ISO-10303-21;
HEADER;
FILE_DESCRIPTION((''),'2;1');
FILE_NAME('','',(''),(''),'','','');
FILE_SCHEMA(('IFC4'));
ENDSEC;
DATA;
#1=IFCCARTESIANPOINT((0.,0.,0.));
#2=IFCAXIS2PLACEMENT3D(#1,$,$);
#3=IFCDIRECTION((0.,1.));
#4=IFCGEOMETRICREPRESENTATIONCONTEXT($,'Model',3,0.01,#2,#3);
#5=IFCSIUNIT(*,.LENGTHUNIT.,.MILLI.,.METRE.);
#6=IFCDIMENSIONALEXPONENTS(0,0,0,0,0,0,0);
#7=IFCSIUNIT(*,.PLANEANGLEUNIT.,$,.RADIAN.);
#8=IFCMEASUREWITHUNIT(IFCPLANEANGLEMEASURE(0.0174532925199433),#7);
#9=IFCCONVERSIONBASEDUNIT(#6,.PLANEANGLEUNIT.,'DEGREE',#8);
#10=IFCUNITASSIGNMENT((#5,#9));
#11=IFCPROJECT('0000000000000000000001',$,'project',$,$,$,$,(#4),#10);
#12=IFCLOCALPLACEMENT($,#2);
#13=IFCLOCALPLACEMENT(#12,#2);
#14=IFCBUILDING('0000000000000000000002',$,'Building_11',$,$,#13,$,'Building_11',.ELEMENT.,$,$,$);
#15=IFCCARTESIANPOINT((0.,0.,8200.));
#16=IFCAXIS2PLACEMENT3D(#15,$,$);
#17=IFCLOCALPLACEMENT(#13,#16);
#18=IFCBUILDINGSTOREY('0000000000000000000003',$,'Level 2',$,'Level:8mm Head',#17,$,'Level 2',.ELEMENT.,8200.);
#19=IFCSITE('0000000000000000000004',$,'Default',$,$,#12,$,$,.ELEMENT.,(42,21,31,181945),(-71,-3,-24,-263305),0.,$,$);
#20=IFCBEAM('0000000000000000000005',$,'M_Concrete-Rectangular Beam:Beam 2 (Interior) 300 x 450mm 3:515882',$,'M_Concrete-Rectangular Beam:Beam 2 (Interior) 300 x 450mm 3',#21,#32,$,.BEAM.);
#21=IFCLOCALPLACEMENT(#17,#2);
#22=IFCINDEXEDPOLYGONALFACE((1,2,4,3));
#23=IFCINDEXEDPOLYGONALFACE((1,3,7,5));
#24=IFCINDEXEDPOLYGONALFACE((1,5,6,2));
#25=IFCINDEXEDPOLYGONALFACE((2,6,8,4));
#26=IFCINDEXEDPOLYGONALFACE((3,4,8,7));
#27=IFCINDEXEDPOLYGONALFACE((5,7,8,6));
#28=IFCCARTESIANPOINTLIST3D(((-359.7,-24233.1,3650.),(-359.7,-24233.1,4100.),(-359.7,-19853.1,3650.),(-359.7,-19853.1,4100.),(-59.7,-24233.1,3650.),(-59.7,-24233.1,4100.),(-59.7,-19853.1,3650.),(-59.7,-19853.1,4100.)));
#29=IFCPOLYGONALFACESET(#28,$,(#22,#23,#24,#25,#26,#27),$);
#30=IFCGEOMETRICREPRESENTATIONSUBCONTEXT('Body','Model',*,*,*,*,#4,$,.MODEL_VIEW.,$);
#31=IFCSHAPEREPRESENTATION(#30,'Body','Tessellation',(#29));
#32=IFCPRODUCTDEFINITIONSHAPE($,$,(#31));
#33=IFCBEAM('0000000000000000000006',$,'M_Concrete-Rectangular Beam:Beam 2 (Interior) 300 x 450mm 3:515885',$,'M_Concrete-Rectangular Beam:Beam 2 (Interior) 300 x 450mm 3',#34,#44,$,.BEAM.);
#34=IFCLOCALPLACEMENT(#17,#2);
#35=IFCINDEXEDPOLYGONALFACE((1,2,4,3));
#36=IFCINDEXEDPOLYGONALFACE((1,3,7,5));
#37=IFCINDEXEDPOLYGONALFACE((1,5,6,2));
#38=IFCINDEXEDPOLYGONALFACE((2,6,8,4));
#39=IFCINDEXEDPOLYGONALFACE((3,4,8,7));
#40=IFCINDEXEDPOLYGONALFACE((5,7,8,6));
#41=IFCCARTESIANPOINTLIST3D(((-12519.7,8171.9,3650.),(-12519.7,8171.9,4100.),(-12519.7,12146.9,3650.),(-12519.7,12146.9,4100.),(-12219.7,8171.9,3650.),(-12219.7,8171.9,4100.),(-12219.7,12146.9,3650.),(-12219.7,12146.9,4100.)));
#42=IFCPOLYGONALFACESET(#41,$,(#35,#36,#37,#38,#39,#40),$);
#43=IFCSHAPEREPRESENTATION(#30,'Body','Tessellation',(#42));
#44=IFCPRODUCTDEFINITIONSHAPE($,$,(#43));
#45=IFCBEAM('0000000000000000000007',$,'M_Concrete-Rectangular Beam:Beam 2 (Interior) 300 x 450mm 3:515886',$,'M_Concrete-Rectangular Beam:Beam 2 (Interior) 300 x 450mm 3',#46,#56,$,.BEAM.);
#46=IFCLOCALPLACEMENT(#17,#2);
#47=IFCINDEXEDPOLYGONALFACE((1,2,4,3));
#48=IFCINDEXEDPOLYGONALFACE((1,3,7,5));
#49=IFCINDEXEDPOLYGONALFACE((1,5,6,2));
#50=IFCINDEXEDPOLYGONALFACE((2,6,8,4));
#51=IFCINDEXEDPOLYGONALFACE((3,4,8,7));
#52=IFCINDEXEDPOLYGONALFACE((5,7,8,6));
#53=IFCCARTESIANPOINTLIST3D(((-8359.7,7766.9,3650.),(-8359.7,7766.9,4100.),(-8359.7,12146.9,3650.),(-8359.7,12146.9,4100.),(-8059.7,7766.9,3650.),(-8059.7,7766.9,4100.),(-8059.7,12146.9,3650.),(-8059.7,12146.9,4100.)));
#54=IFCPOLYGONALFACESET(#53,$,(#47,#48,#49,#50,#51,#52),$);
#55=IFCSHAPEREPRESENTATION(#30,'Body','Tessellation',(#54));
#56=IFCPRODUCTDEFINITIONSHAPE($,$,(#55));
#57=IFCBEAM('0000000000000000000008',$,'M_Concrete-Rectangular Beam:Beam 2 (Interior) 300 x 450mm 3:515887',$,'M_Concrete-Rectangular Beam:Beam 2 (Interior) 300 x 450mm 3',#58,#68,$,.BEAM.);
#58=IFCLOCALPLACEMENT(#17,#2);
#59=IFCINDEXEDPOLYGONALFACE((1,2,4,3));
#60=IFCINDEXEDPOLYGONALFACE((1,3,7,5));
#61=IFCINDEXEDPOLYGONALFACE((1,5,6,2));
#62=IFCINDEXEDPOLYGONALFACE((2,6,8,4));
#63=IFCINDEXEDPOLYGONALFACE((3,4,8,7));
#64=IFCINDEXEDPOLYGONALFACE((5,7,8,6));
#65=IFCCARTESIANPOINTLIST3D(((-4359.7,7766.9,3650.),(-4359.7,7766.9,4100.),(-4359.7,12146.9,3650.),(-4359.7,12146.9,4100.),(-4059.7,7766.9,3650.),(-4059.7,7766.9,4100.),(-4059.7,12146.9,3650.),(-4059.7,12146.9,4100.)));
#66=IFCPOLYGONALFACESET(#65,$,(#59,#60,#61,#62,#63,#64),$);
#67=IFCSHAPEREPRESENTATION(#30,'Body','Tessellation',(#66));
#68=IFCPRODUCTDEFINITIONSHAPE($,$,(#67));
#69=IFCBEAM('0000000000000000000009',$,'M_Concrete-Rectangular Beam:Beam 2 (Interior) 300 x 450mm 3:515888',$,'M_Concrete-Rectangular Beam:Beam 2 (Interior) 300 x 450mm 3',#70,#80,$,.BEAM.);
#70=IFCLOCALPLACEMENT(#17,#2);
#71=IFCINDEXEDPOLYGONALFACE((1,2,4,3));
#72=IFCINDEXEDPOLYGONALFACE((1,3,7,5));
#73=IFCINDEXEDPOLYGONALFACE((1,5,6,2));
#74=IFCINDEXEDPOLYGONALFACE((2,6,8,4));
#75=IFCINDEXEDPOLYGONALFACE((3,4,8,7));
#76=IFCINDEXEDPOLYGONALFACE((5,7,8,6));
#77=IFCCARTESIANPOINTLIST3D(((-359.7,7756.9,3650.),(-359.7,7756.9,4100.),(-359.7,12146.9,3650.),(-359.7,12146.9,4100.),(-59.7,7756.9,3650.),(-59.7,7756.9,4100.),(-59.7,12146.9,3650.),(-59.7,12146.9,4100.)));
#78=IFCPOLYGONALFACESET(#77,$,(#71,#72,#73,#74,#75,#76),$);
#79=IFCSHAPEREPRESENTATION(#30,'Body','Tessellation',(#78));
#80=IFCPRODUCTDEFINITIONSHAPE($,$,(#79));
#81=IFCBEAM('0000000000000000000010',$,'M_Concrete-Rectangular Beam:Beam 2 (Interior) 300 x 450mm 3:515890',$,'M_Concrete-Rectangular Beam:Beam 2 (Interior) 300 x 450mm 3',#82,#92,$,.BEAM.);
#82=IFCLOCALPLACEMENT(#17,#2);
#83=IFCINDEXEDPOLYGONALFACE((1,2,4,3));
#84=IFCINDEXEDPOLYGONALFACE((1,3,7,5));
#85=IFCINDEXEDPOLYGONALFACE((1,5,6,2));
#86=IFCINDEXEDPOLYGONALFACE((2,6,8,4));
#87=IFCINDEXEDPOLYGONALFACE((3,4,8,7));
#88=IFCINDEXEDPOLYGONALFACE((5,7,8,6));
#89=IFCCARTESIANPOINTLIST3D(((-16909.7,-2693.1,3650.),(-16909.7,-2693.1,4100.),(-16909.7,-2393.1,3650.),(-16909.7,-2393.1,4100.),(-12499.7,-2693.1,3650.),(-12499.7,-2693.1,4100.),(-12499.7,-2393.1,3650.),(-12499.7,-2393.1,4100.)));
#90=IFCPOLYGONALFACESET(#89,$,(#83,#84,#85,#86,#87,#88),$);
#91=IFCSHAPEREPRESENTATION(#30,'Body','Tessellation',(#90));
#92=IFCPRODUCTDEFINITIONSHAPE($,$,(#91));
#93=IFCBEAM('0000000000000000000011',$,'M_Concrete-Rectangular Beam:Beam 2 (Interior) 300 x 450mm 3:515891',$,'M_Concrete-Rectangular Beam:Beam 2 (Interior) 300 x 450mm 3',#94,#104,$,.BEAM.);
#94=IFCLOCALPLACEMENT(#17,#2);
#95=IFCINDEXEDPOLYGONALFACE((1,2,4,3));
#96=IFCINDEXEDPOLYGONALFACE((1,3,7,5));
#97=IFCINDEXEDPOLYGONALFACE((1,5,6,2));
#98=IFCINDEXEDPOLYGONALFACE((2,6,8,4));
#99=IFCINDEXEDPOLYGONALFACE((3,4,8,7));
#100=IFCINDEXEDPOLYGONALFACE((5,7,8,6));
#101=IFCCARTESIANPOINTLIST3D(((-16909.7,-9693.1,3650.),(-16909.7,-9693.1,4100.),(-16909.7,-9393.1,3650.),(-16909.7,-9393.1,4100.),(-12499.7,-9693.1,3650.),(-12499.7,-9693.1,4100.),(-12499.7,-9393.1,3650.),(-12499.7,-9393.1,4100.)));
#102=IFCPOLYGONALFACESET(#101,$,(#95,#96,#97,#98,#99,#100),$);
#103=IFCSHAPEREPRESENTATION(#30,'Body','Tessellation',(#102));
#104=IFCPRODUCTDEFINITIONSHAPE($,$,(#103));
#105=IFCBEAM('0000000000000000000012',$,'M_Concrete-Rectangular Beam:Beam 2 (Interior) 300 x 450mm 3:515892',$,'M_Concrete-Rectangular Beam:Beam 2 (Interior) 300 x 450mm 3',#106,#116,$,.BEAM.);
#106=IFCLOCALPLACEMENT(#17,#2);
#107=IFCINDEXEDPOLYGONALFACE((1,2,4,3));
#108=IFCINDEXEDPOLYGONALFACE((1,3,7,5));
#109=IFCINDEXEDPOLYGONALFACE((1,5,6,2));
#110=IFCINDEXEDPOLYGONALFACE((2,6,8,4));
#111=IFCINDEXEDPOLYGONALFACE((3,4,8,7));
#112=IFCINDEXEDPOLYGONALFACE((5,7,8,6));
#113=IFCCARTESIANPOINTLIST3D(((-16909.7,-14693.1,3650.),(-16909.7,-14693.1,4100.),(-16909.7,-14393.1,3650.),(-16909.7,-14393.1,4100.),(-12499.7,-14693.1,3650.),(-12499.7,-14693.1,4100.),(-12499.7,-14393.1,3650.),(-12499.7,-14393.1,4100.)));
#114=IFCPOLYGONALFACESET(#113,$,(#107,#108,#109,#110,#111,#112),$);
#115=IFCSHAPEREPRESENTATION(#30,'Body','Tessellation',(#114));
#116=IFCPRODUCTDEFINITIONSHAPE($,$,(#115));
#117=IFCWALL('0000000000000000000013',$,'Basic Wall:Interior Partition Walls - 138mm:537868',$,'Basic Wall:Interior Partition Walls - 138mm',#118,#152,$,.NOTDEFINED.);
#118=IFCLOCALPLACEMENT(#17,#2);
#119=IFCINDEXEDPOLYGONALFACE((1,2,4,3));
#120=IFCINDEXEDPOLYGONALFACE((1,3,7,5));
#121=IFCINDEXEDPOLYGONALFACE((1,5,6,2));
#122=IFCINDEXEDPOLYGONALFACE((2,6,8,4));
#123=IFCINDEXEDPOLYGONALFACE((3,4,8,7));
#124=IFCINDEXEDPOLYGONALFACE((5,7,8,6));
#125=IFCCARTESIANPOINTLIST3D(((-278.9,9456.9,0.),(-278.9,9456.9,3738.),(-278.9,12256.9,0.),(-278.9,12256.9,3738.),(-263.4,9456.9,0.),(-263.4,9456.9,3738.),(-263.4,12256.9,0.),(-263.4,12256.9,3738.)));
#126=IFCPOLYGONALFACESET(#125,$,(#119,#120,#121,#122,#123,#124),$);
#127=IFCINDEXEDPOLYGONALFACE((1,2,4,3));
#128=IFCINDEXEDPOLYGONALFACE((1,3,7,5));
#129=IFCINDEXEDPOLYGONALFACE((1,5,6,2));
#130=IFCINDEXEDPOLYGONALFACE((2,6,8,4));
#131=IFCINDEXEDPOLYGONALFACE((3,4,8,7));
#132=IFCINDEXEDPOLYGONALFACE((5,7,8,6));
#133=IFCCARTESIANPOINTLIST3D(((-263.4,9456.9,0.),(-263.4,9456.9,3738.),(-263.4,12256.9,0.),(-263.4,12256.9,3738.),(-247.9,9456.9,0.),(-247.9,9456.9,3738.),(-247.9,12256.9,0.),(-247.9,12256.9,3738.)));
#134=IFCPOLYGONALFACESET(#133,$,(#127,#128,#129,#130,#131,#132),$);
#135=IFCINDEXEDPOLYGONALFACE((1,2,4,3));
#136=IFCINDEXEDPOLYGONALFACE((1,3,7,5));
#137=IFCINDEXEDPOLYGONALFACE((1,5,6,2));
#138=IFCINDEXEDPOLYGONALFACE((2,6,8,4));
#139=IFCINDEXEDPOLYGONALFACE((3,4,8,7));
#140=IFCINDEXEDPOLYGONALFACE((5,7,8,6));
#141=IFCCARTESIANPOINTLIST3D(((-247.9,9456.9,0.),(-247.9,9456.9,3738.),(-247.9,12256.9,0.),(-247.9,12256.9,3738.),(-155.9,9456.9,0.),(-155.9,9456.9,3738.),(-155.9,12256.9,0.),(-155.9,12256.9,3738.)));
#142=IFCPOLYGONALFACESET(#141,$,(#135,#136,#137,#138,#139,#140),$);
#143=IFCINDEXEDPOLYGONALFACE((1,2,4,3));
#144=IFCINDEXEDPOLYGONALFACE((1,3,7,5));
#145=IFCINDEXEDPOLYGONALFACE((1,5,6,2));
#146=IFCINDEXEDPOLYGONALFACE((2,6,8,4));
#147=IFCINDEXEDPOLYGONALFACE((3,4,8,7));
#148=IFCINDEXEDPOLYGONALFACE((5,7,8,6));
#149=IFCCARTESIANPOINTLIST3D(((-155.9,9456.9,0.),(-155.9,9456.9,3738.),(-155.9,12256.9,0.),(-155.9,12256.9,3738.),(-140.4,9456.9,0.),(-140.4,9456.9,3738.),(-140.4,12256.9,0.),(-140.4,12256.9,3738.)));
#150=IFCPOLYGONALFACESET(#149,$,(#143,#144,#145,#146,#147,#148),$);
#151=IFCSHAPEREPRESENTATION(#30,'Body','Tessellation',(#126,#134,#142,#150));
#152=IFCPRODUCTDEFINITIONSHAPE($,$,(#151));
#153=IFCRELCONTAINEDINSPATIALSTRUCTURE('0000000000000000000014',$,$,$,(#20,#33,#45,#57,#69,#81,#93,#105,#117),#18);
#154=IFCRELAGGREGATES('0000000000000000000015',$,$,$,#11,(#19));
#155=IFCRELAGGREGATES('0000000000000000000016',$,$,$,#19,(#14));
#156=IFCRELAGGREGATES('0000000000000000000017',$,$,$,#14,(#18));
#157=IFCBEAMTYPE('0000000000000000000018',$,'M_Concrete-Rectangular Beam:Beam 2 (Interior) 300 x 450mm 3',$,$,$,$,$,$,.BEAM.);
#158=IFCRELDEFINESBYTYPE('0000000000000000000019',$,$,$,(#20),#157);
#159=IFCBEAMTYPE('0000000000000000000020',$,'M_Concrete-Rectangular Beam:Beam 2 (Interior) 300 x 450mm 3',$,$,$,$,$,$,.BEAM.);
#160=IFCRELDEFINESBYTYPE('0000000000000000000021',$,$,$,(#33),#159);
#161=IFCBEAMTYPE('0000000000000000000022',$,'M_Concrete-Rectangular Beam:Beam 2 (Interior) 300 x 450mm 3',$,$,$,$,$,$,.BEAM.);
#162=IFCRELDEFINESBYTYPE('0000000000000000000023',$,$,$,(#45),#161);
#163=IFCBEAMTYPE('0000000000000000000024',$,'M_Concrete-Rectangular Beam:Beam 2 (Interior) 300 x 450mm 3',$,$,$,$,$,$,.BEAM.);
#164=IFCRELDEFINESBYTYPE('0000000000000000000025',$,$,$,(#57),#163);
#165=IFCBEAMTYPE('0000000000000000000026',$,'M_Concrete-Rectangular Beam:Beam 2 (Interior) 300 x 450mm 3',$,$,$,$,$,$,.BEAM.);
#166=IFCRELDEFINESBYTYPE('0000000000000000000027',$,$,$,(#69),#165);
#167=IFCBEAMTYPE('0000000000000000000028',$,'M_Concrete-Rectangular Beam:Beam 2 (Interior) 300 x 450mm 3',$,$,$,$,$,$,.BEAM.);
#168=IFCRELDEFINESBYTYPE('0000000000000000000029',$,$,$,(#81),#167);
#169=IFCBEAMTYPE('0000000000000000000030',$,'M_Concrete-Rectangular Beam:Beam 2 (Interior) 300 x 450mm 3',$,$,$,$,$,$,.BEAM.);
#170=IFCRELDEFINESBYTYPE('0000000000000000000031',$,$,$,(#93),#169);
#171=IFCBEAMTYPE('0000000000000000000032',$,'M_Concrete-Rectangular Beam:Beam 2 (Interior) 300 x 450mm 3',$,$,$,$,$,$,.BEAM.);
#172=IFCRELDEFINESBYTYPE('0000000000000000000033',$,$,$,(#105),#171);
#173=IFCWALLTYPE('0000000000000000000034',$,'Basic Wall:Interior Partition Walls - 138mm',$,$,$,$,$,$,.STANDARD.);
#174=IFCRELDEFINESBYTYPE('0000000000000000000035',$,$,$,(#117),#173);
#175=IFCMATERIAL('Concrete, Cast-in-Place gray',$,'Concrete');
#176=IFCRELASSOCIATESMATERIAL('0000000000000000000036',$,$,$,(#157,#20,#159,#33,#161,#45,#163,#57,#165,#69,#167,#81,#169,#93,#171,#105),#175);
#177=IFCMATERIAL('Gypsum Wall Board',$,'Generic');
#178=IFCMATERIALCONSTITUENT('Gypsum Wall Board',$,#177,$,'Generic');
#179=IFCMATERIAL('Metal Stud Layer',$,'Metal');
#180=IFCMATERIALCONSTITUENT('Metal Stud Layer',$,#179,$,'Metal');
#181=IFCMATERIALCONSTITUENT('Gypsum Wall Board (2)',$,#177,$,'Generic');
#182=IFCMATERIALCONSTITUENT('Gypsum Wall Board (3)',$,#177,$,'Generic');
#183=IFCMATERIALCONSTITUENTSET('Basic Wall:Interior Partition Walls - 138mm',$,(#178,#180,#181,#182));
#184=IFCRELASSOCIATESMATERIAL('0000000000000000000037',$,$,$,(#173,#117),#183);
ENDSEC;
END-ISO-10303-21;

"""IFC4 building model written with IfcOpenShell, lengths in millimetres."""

from ifc_helpers import new_model, entity, si_unit, converted_unit, direction, frame, origin, place, context, subcontext, project, spatial, indexed_curve, outline, extrude, source, transform, mapped, material, constituent, constituent_set, type_object, type_shapes, element, save


model = new_model("IFC4")

# Units and contexts
model_context = context("Model", 3, precision=0.01, world=origin(), true_north=direction((0.0, 1.0)))
body_context = subcontext(model_context, "Body", "Model", "MODEL_VIEW")
ifc_project = project(units=[si_unit("LENGTHUNIT", "METRE", prefix="MILLI"), converted_unit("PLANEANGLEUNIT", "DEGREE", entity("IfcPlaneAngleMeasure", 0.0174532925199433), si_unit("PLANEANGLEUNIT", "RADIAN"), dimensions=[0, 0, 0, 0, 0, 0, 0])], contexts=[model_context])

# Site, building, storey
site_placement = place(None, origin())
site = spatial("IfcSite", under=ifc_project, at=site_placement, Name="Default", CompositionType="ELEMENT", RefLatitude=(42, 21, 31, 181945), RefLongitude=(-71, -3, -24, -263305), RefElevation=0.0)
building_placement = place(site_placement, origin())
building = spatial("IfcBuilding", under=site, at=building_placement, Name="Building_11", LongName="Building_11", CompositionType="ELEMENT")
storey_placement = place(building_placement, frame((0.0, 0.0, 8200.0)))
storey = spatial("IfcBuildingStorey", under=building, at=storey_placement, Name="Level 2", ObjectType="Level:8mm Head", LongName="Level 2", CompositionType="ELEMENT", Elevation=8200.0)

# Beams
ifc_material_1 = material(Name="Concrete, Cast-in-Place gray", Category="Concrete")
beam_type_1 = type_object("IfcBeamType", Name="M_Concrete-Rectangular Beam:Beam 2 (Interior) 300 x 450mm 3", PredefinedType="BEAM", material=ifc_material_1)
shared_shape_1 = source(origin(), body_context, "Body", "SweptSolid", [
    extrude(outline(indexed_curve([(-150.0, -225.0), (150.0, -225.0), (150.0, 225.0), (-150.0, 225.0), (-150.0, -225.0)], self_intersect=False)), frame((-209.7, -19853.1, 12075.0), z_axis=(0.0, -1.0, 0.0), x_axis=(-1.0, 0.0, 0.0)), (0.0, 0.0, 1.0), 4380.0),
])
type_shapes(beam_type_1, [shared_shape_1])
beam_1_placement = place(storey_placement, frame((0.0, 0.0, -8200.0)))
element("IfcBeam", 1, at=beam_1_placement, inside=storey, type_object=beam_type_1, material=ifc_material_1, Name="M_Concrete-Rectangular Beam:Beam 2 (Interior) 300 x 450mm 3:515882", ObjectType="M_Concrete-Rectangular Beam:Beam 2 (Interior) 300 x 450mm 3", PredefinedType="BEAM", context=body_context, shape_type="MappedRepresentation", body=[
    mapped(shared_shape_1, transform((0.0, 0.0, 0.0), scale=1.0)),
])
beam_type_2 = type_object("IfcBeamType", Name="M_Concrete-Rectangular Beam:Beam 2 (Interior) 300 x 450mm 3", PredefinedType="BEAM", material=ifc_material_1)
shared_shape_2 = source(origin(), body_context, "Body", "SweptSolid", [
    extrude(outline(indexed_curve([(-150.0, -225.0), (150.0, -225.0), (150.0, 225.0), (-150.0, 225.0), (-150.0, -225.0)], self_intersect=False)), frame((-12369.7, 12146.9, 12075.0), z_axis=(0.0, -1.0, 0.0), x_axis=(-1.0, 0.0, 0.0)), (0.0, 0.0, 1.0), 3975.0),
])
type_shapes(beam_type_2, [shared_shape_2])
beam_2_placement = place(storey_placement, frame((0.0, 0.0, -8200.0)))
element("IfcBeam", 2, at=beam_2_placement, inside=storey, type_object=beam_type_2, material=ifc_material_1, Name="M_Concrete-Rectangular Beam:Beam 2 (Interior) 300 x 450mm 3:515885", ObjectType="M_Concrete-Rectangular Beam:Beam 2 (Interior) 300 x 450mm 3", PredefinedType="BEAM", context=body_context, shape_type="MappedRepresentation", body=[
    mapped(shared_shape_2, transform((0.0, 0.0, 0.0), scale=1.0)),
])
beam_type_3 = type_object("IfcBeamType", Name="M_Concrete-Rectangular Beam:Beam 2 (Interior) 300 x 450mm 3", PredefinedType="BEAM", material=ifc_material_1)
shared_shape_3 = source(origin(), body_context, "Body", "SweptSolid", [
    extrude(outline(indexed_curve([(-150.0, -225.0), (150.0, -225.0), (150.0, 225.0), (-150.0, 225.0), (-150.0, -225.0)], self_intersect=False)), frame((-8209.7, 12146.9, 12075.0), z_axis=(0.0, -1.0, 0.0), x_axis=(-1.0, 0.0, 0.0)), (0.0, 0.0, 1.0), 4380.0),
])
type_shapes(beam_type_3, [shared_shape_3])
beam_3_placement = place(storey_placement, frame((0.0, 0.0, -8200.0)))
element("IfcBeam", 3, at=beam_3_placement, inside=storey, type_object=beam_type_3, material=ifc_material_1, Name="M_Concrete-Rectangular Beam:Beam 2 (Interior) 300 x 450mm 3:515886", ObjectType="M_Concrete-Rectangular Beam:Beam 2 (Interior) 300 x 450mm 3", PredefinedType="BEAM", context=body_context, shape_type="MappedRepresentation", body=[
    mapped(shared_shape_3, transform((0.0, 0.0, 0.0), scale=1.0)),
])
beam_type_4 = type_object("IfcBeamType", Name="M_Concrete-Rectangular Beam:Beam 2 (Interior) 300 x 450mm 3", PredefinedType="BEAM", material=ifc_material_1)
shared_shape_4 = source(origin(), body_context, "Body", "SweptSolid", [
    extrude(outline(indexed_curve([(-150.0, -225.0), (150.0, -225.0), (150.0, 225.0), (-150.0, 225.0), (-150.0, -225.0)], self_intersect=False)), frame((-4209.7, 12146.9, 12075.0), z_axis=(0.0, -1.0, 0.0), x_axis=(-1.0, 0.0, 0.0)), (0.0, 0.0, 1.0), 4380.0),
])
type_shapes(beam_type_4, [shared_shape_4])
beam_4_placement = place(storey_placement, frame((0.0, 0.0, -8200.0)))
element("IfcBeam", 4, at=beam_4_placement, inside=storey, type_object=beam_type_4, material=ifc_material_1, Name="M_Concrete-Rectangular Beam:Beam 2 (Interior) 300 x 450mm 3:515887", ObjectType="M_Concrete-Rectangular Beam:Beam 2 (Interior) 300 x 450mm 3", PredefinedType="BEAM", context=body_context, shape_type="MappedRepresentation", body=[
    mapped(shared_shape_4, transform((0.0, 0.0, 0.0), scale=1.0)),
])
beam_type_5 = type_object("IfcBeamType", Name="M_Concrete-Rectangular Beam:Beam 2 (Interior) 300 x 450mm 3", PredefinedType="BEAM", material=ifc_material_1)
shared_shape_5 = source(origin(), body_context, "Body", "SweptSolid", [
    extrude(outline(indexed_curve([(-150.0, -225.0), (150.0, -225.0), (150.0, 225.0), (-150.0, 225.0), (-150.0, -225.0)], self_intersect=False)), frame((-209.7, 12146.9, 12075.0), z_axis=(0.0, -1.0, 0.0), x_axis=(-1.0, 0.0, 0.0)), (0.0, 0.0, 1.0), 4390.0),
])
type_shapes(beam_type_5, [shared_shape_5])
beam_5_placement = place(storey_placement, frame((0.0, 0.0, -8200.0)))
element("IfcBeam", 5, at=beam_5_placement, inside=storey, type_object=beam_type_5, material=ifc_material_1, Name="M_Concrete-Rectangular Beam:Beam 2 (Interior) 300 x 450mm 3:515888", ObjectType="M_Concrete-Rectangular Beam:Beam 2 (Interior) 300 x 450mm 3", PredefinedType="BEAM", context=body_context, shape_type="MappedRepresentation", body=[
    mapped(shared_shape_5, transform((0.0, 0.0, 0.0), scale=1.0)),
])
beam_type_6 = type_object("IfcBeamType", Name="M_Concrete-Rectangular Beam:Beam 2 (Interior) 300 x 450mm 3", PredefinedType="BEAM", material=ifc_material_1)
shared_shape_6 = source(origin(), body_context, "Body", "SweptSolid", [
    extrude(outline(indexed_curve([(-225.0, -150.0), (225.0, -150.0), (225.0, 150.0), (-225.0, 150.0), (-225.0, -150.0)], self_intersect=False)), frame((-16909.7, -2543.1, 12075.0), z_axis=(1.0, 0.0, 0.0), x_axis=(0.0, 0.0, -1.0)), (0.0, 0.0, 1.0), 4410.0),
])
type_shapes(beam_type_6, [shared_shape_6])
beam_6_placement = place(storey_placement, frame((0.0, 0.0, -8200.0)))
element("IfcBeam", 6, at=beam_6_placement, inside=storey, type_object=beam_type_6, material=ifc_material_1, Name="M_Concrete-Rectangular Beam:Beam 2 (Interior) 300 x 450mm 3:515890", ObjectType="M_Concrete-Rectangular Beam:Beam 2 (Interior) 300 x 450mm 3", PredefinedType="BEAM", context=body_context, shape_type="MappedRepresentation", body=[
    mapped(shared_shape_6, transform((0.0, 0.0, 0.0), scale=1.0)),
])
beam_type_7 = type_object("IfcBeamType", Name="M_Concrete-Rectangular Beam:Beam 2 (Interior) 300 x 450mm 3", PredefinedType="BEAM", material=ifc_material_1)
shared_shape_7 = source(origin(), body_context, "Body", "SweptSolid", [
    extrude(outline(indexed_curve([(-225.0, -150.0), (225.0, -150.0), (225.0, 150.0), (-225.0, 150.0), (-225.0, -150.0)], self_intersect=False)), frame((-16909.7, -9543.1, 12075.0), z_axis=(1.0, 0.0, 0.0), x_axis=(0.0, 0.0, -1.0)), (0.0, 0.0, 1.0), 4410.0),
])
type_shapes(beam_type_7, [shared_shape_7])
beam_7_placement = place(storey_placement, frame((0.0, 0.0, -8200.0)))
element("IfcBeam", 7, at=beam_7_placement, inside=storey, type_object=beam_type_7, material=ifc_material_1, Name="M_Concrete-Rectangular Beam:Beam 2 (Interior) 300 x 450mm 3:515891", ObjectType="M_Concrete-Rectangular Beam:Beam 2 (Interior) 300 x 450mm 3", PredefinedType="BEAM", context=body_context, shape_type="MappedRepresentation", body=[
    mapped(shared_shape_7, transform((0.0, 0.0, 0.0), scale=1.0)),
])
beam_type_8 = type_object("IfcBeamType", Name="M_Concrete-Rectangular Beam:Beam 2 (Interior) 300 x 450mm 3", PredefinedType="BEAM", material=ifc_material_1)
shared_shape_8 = source(origin(), body_context, "Body", "SweptSolid", [
    extrude(outline(indexed_curve([(-225.0, -150.0), (225.0, -150.0), (225.0, 150.0), (-225.0, 150.0), (-225.0, -150.0)], self_intersect=False)), frame((-16909.7, -14543.1, 12075.0), z_axis=(1.0, 0.0, 0.0), x_axis=(0.0, 0.0, -1.0)), (0.0, 0.0, 1.0), 4410.0),
])
type_shapes(beam_type_8, [shared_shape_8])
beam_8_placement = place(storey_placement, frame((0.0, 0.0, -8200.0)))
element("IfcBeam", 8, at=beam_8_placement, inside=storey, type_object=beam_type_8, material=ifc_material_1, Name="M_Concrete-Rectangular Beam:Beam 2 (Interior) 300 x 450mm 3:515892", ObjectType="M_Concrete-Rectangular Beam:Beam 2 (Interior) 300 x 450mm 3", PredefinedType="BEAM", context=body_context, shape_type="MappedRepresentation", body=[
    mapped(shared_shape_8, transform((0.0, 0.0, 0.0), scale=1.0)),
])

# Wall
ifc_material_2 = material(Name="Gypsum Wall Board", Category="Generic")
ifc_constituent_1 = constituent(ifc_material_2, Name="Gypsum Wall Board", Category="Generic")
ifc_material_3 = material(Name="Metal Stud Layer", Category="Metal")
ifc_constituent_2 = constituent(ifc_material_3, Name="Metal Stud Layer", Category="Metal")
ifc_constituent_3 = constituent(ifc_material_2, Name="Gypsum Wall Board (2)", Category="Generic")
ifc_constituent_4 = constituent(ifc_material_2, Name="Gypsum Wall Board (3)", Category="Generic")
ifc_constituent_set_1 = constituent_set(constituents=[ifc_constituent_1, ifc_constituent_2, ifc_constituent_3, ifc_constituent_4], Name="Basic Wall:Interior Partition Walls - 138mm")
wall_type = type_object("IfcWallType", Name="Basic Wall:Interior Partition Walls - 138mm", PredefinedType="STANDARD", material=ifc_constituent_set_1)
wall_placement = place(storey_placement, frame((-209.7, 12256.9, 0.0), z_axis=(0.0, 0.0, 1.0), x_axis=(0.0, -1.0, 0.0)))
element("IfcWall", 9, at=wall_placement, inside=storey, type_object=wall_type, material=ifc_constituent_set_1, Name="Basic Wall:Interior Partition Walls - 138mm:537868", ObjectType="Basic Wall:Interior Partition Walls - 138mm", PredefinedType="NOTDEFINED", context=body_context, shape_type="SweptSolid", body=[
    extrude(outline(indexed_curve([(-1869.0, -1400.0), (1869.0, -1400.0), (1869.0, 1400.0), (-1869.0, 1400.0), (-1869.0, -1400.0)], self_intersect=False)), frame((1400.0, -69.2, 1869.0), z_axis=(0.0, 1.0, 0.0), x_axis=(0.0, 0.0, 1.0)), (0.0, 0.0, 1.0), 15.5),
    extrude(outline(indexed_curve([(-1869.0, -1400.0), (1869.0, -1400.0), (1869.0, 1400.0), (-1869.0, 1400.0), (-1869.0, -1400.0)], self_intersect=False)), frame((1400.0, -53.8, 1869.0), z_axis=(0.0, 1.0, 0.0), x_axis=(0.0, 0.0, 1.0)), (0.0, 0.0, 1.0), 15.5),
    extrude(outline(indexed_curve([(-1869.0, -1400.0), (1869.0, -1400.0), (1869.0, 1400.0), (-1869.0, 1400.0), (-1869.0, -1400.0)], self_intersect=False)), frame((1400.0, -38.2, 1869.0), z_axis=(0.0, 1.0, 0.0), x_axis=(0.0, 0.0, 1.0)), (0.0, 0.0, 1.0), 92.0),
    extrude(outline(indexed_curve([(-1869.0, -1400.0), (1869.0, -1400.0), (1869.0, 1400.0), (-1869.0, 1400.0), (-1869.0, -1400.0)], self_intersect=False)), frame((1400.0, 53.7, 1869.0), z_axis=(0.0, 1.0, 0.0), x_axis=(0.0, 0.0, 1.0)), (0.0, 0.0, 1.0), 15.5),
])

save(model, "model.ifc")
